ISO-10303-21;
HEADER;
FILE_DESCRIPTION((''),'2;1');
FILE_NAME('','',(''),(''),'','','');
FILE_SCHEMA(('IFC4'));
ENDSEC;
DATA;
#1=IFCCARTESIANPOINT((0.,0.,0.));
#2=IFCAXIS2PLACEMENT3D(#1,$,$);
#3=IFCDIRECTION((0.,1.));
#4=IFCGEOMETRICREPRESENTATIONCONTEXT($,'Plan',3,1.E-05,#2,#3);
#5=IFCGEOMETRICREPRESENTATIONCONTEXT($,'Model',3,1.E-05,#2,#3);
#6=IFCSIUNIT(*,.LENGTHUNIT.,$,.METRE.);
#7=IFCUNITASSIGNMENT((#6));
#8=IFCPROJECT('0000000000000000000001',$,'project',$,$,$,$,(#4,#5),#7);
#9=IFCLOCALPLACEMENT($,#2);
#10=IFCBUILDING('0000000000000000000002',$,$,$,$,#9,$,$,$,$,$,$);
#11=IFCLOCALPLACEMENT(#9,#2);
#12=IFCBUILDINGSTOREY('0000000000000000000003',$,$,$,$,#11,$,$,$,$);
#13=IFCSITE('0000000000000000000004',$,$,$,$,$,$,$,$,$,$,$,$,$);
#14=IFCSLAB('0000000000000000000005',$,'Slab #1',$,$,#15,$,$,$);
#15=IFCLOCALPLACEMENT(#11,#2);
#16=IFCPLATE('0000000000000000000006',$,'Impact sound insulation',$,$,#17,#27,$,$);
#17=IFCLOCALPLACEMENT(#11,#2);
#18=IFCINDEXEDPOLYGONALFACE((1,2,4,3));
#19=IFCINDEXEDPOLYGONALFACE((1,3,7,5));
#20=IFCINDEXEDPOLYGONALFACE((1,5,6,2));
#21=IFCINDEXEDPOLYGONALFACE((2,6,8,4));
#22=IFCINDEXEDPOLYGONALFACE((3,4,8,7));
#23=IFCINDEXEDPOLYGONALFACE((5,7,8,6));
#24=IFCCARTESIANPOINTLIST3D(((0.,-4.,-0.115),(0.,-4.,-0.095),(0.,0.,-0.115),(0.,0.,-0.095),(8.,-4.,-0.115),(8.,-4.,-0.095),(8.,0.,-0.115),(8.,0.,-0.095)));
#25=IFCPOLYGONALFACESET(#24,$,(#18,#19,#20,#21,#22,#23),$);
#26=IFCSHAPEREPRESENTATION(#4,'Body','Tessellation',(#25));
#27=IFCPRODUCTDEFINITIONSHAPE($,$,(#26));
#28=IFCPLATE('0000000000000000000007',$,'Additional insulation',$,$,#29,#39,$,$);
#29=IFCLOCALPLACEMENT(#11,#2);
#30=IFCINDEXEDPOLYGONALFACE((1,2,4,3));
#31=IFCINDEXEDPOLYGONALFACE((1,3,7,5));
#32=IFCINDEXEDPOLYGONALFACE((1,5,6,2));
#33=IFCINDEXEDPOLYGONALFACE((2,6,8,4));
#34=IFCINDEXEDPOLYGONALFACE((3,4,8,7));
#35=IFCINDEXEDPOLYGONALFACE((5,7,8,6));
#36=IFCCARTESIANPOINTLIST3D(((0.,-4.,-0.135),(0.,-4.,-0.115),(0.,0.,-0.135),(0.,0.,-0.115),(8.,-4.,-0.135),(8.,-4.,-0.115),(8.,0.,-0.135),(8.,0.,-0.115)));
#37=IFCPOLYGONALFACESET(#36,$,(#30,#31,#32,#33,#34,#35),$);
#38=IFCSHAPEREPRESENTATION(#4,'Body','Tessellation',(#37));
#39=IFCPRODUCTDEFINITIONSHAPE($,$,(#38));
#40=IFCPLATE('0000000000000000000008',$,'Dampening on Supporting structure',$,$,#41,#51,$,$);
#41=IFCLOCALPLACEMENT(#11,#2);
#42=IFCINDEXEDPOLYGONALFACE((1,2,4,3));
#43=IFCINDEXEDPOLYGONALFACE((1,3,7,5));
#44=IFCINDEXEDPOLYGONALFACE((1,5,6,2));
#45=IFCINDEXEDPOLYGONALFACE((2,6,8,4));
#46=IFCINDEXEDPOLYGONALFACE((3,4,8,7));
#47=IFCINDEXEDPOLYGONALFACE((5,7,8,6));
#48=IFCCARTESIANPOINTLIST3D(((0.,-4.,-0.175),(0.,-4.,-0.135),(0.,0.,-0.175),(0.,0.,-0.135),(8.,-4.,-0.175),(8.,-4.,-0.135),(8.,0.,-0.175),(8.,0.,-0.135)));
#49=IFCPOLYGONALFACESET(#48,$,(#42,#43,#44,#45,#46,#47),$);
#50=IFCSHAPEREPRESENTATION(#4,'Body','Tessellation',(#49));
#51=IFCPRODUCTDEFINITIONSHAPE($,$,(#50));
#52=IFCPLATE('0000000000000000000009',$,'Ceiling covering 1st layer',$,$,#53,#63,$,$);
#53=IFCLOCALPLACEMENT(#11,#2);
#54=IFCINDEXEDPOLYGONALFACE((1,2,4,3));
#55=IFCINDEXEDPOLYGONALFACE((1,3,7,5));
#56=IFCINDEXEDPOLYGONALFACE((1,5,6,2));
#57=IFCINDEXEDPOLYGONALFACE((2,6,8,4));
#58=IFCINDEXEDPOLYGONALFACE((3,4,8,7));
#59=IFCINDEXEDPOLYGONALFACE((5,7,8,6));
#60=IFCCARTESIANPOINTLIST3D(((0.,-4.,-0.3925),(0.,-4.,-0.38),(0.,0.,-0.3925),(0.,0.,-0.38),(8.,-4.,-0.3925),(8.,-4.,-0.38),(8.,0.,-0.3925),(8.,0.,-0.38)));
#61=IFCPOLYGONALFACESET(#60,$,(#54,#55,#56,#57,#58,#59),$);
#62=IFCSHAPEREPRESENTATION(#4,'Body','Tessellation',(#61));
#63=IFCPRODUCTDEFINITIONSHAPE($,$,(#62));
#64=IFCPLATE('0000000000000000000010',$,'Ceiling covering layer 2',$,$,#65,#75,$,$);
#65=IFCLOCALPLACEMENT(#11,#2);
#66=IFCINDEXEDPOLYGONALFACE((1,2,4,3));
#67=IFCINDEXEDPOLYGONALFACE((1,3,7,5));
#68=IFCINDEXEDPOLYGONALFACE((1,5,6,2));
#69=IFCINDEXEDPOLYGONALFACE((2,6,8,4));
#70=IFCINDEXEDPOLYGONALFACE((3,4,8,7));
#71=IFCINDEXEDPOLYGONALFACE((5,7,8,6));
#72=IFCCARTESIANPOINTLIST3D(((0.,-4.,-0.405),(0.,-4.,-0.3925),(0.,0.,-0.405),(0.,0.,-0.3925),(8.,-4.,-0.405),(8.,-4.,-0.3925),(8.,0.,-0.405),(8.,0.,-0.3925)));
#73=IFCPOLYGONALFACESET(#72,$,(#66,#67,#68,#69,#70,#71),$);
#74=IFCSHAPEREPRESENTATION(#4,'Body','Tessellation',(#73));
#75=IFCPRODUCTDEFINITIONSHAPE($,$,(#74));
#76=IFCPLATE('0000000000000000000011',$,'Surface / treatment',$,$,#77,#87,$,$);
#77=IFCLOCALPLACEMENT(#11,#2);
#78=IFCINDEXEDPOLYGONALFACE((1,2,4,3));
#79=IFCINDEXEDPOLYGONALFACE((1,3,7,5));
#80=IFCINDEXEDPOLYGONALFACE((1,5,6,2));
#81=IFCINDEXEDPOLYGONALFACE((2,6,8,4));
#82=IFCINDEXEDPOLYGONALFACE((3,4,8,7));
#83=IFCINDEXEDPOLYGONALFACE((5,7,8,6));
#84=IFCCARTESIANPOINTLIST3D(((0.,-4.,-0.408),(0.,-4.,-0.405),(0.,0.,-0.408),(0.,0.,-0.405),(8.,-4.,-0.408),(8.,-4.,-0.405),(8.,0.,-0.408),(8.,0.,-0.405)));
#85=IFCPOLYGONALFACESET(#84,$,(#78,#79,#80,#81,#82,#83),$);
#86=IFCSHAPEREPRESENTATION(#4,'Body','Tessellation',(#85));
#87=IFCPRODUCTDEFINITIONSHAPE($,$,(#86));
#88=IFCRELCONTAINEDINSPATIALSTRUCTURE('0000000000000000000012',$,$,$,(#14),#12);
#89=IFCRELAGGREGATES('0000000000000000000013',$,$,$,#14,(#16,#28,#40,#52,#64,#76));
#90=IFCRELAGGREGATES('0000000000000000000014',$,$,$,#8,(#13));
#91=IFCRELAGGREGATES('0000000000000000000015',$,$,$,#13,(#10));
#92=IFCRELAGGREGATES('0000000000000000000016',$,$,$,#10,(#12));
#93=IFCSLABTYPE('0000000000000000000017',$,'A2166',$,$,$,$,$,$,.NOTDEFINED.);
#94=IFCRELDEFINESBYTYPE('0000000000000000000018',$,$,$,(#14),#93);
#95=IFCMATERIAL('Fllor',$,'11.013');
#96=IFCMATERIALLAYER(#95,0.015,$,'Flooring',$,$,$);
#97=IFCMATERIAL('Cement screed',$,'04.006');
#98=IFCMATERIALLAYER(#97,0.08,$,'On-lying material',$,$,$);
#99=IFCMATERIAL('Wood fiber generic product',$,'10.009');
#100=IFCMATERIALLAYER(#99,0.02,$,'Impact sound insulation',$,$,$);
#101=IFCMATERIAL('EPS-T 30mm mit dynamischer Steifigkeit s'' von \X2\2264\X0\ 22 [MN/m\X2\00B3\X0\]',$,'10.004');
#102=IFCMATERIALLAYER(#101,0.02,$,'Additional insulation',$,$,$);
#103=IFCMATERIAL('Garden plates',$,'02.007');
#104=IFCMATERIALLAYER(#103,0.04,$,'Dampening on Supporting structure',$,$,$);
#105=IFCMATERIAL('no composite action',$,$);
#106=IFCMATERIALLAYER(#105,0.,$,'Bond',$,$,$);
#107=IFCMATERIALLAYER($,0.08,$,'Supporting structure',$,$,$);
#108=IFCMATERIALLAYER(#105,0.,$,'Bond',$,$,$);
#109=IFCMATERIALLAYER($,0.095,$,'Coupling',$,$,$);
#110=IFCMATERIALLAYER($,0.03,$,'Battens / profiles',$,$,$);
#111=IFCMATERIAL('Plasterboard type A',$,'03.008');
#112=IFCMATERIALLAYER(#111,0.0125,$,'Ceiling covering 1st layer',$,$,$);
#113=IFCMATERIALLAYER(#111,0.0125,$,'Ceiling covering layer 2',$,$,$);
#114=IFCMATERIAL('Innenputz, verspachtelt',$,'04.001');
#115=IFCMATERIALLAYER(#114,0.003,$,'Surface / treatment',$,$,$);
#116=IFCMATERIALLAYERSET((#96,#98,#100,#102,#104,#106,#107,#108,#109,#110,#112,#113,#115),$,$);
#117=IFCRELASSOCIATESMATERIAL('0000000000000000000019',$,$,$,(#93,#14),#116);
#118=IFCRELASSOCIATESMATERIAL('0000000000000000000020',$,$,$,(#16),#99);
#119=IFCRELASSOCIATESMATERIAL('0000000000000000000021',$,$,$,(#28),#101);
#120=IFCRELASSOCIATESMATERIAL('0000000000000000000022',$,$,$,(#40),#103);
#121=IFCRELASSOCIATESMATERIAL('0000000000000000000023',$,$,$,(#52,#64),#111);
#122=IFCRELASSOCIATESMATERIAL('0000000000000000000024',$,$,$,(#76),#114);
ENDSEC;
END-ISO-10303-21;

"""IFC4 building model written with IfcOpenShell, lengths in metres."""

from ifc_helpers import new_model, si_unit, direction, frame, frame_2d, origin, place, context, project, spatial, rectangle, extrude, material, layer, layer_set, type_object, element, aggregate, save


model = new_model("IFC4")

# Units and contexts
plan_context = context("Plan", 3, precision=1e-05, world=origin(), true_north=direction((0.0, 1.0)))
model_context = context("Model", 3, precision=1e-05, world=origin(), true_north=direction((0.0, 1.0)))
ifc_project = project(units=[si_unit("LENGTHUNIT", "METRE")], contexts=[plan_context, model_context])

# Site, building, storey
site = spatial("IfcSite", under=ifc_project)
building_placement = place(None, origin())
building = spatial("IfcBuilding", under=site, at=building_placement)
storey_placement = place(building_placement, origin())
storey = spatial("IfcBuildingStorey", under=building, at=storey_placement)

# Slab, plates
ifc_material_1 = material(Name="Fllor", Category="11.013")
ifc_layer_1 = layer(ifc_material_1, 0.015, Name="Flooring")
ifc_material_2 = material(Name="Cement screed", Category="04.006")
ifc_layer_2 = layer(ifc_material_2, 0.08, Name="On-lying material")
ifc_material_3 = material(Name="Wood fiber generic product", Category="10.009")
ifc_layer_3 = layer(ifc_material_3, 0.02, Name="Impact sound insulation")
ifc_material_4 = material(Name="EPS-T 30mm mit dynamischer Steifigkeit s' von ≤ 22 [MN/m³]", Category="10.004")
ifc_layer_4 = layer(ifc_material_4, 0.02, Name="Additional insulation")
ifc_material_5 = material(Name="Garden plates", Category="02.007")
ifc_layer_5 = layer(ifc_material_5, 0.04, Name="Dampening on Supporting structure")
ifc_material_6 = material(Name="no composite action")
ifc_layer_6 = layer(ifc_material_6, 0.0, Name="Bond")
ifc_layer_7 = layer(None, 0.08, Name="Supporting structure")
ifc_layer_8 = layer(ifc_material_6, 0.0, Name="Bond")
ifc_layer_9 = layer(None, 0.095, Name="Coupling")
ifc_layer_10 = layer(None, 0.03, Name="Battens / profiles")
ifc_material_7 = material(Name="Plasterboard type A", Category="03.008")
ifc_layer_11 = layer(ifc_material_7, 0.0125, Name="Ceiling covering 1st layer")
ifc_layer_12 = layer(ifc_material_7, 0.0125, Name="Ceiling covering layer 2")
ifc_material_8 = material(Name="Innenputz, verspachtelt", Category="04.001")
ifc_layer_13 = layer(ifc_material_8, 0.003, Name="Surface / treatment")
ifc_layer_set = layer_set([ifc_layer_1, ifc_layer_2, ifc_layer_3, ifc_layer_4, ifc_layer_5, ifc_layer_6, ifc_layer_7, ifc_layer_8, ifc_layer_9, ifc_layer_10, ifc_layer_11, ifc_layer_12, ifc_layer_13])
slab_type = type_object("IfcSlabType", Name="A2166", PredefinedType="NOTDEFINED", material=ifc_layer_set)
slab_placement = place(None, frame((0.0, 0.0, 0.0), z_axis=(0.0, 0.0, -1.0), x_axis=(1.0, 0.0, 0.0)))
slab = element("IfcSlab", 1, at=slab_placement, inside=storey, type_object=slab_type, material=ifc_layer_set, Name="Slab #1")
plate_1_placement = place(slab_placement, origin())
plate_1 = element("IfcPlate", 2, at=plate_1_placement, material=ifc_material_3, Name="Impact sound insulation", context=plan_context, shape_type="SweptSolid", body=[
    extrude(rectangle(XDim=8.0, YDim=4.0, at=frame_2d((4.0, 2.0), x_axis=(1.0, 0.0))), frame((0.0, 0.0, 0.095), z_axis=(0.0, 0.0, 1.0), x_axis=(1.0, 0.0, 0.0)), (0.0, 0.0, 1.0), 0.02),
])
plate_2_placement = place(slab_placement, origin())
plate_2 = element("IfcPlate", 3, at=plate_2_placement, material=ifc_material_4, Name="Additional insulation", context=plan_context, shape_type="SweptSolid", body=[
    extrude(rectangle(XDim=8.0, YDim=4.0, at=frame_2d((4.0, 2.0), x_axis=(1.0, 0.0))), frame((0.0, 0.0, 0.115), z_axis=(0.0, 0.0, 1.0), x_axis=(1.0, 0.0, 0.0)), (0.0, 0.0, 1.0), 0.02),
])
plate_3_placement = place(slab_placement, origin())
plate_3 = element("IfcPlate", 4, at=plate_3_placement, material=ifc_material_5, Name="Dampening on Supporting structure", context=plan_context, shape_type="SweptSolid", body=[
    extrude(rectangle(XDim=8.0, YDim=4.0, at=frame_2d((4.0, 2.0), x_axis=(1.0, 0.0))), frame((0.0, 0.0, 0.135), z_axis=(0.0, 0.0, 1.0), x_axis=(1.0, 0.0, 0.0)), (0.0, 0.0, 1.0), 0.04),
])
plate_4_placement = place(slab_placement, origin())
plate_4 = element("IfcPlate", 5, at=plate_4_placement, material=ifc_material_7, Name="Ceiling covering 1st layer", context=plan_context, shape_type="SweptSolid", body=[
    extrude(rectangle(XDim=8.0, YDim=4.0, at=frame_2d((4.0, 2.0), x_axis=(1.0, 0.0))), frame((0.0, 0.0, 0.38), z_axis=(0.0, 0.0, 1.0), x_axis=(1.0, 0.0, 0.0)), (0.0, 0.0, 1.0), 0.0125),
])
plate_5_placement = place(slab_placement, origin())
plate_5 = element("IfcPlate", 6, at=plate_5_placement, material=ifc_material_7, Name="Ceiling covering layer 2", context=plan_context, shape_type="SweptSolid", body=[
    extrude(rectangle(XDim=8.0, YDim=4.0, at=frame_2d((4.0, 2.0), x_axis=(1.0, 0.0))), frame((0.0, 0.0, 0.3925), z_axis=(0.0, 0.0, 1.0), x_axis=(1.0, 0.0, 0.0)), (0.0, 0.0, 1.0), 0.0125),
])
plate_6_placement = place(slab_placement, origin())
plate_6 = element("IfcPlate", 7, at=plate_6_placement, material=ifc_material_8, Name="Surface / treatment", context=plan_context, shape_type="SweptSolid", body=[
    extrude(rectangle(XDim=8.0, YDim=4.0, at=frame_2d((4.0, 2.0), x_axis=(1.0, 0.0))), frame((0.0, 0.0, 0.405), z_axis=(0.0, 0.0, 1.0), x_axis=(1.0, 0.0, 0.0)), (0.0, 0.0, 1.0), 0.003),
])
aggregate(slab, [plate_1, plate_2, plate_3, plate_4, plate_5, plate_6])

save(model, "model.ifc")
